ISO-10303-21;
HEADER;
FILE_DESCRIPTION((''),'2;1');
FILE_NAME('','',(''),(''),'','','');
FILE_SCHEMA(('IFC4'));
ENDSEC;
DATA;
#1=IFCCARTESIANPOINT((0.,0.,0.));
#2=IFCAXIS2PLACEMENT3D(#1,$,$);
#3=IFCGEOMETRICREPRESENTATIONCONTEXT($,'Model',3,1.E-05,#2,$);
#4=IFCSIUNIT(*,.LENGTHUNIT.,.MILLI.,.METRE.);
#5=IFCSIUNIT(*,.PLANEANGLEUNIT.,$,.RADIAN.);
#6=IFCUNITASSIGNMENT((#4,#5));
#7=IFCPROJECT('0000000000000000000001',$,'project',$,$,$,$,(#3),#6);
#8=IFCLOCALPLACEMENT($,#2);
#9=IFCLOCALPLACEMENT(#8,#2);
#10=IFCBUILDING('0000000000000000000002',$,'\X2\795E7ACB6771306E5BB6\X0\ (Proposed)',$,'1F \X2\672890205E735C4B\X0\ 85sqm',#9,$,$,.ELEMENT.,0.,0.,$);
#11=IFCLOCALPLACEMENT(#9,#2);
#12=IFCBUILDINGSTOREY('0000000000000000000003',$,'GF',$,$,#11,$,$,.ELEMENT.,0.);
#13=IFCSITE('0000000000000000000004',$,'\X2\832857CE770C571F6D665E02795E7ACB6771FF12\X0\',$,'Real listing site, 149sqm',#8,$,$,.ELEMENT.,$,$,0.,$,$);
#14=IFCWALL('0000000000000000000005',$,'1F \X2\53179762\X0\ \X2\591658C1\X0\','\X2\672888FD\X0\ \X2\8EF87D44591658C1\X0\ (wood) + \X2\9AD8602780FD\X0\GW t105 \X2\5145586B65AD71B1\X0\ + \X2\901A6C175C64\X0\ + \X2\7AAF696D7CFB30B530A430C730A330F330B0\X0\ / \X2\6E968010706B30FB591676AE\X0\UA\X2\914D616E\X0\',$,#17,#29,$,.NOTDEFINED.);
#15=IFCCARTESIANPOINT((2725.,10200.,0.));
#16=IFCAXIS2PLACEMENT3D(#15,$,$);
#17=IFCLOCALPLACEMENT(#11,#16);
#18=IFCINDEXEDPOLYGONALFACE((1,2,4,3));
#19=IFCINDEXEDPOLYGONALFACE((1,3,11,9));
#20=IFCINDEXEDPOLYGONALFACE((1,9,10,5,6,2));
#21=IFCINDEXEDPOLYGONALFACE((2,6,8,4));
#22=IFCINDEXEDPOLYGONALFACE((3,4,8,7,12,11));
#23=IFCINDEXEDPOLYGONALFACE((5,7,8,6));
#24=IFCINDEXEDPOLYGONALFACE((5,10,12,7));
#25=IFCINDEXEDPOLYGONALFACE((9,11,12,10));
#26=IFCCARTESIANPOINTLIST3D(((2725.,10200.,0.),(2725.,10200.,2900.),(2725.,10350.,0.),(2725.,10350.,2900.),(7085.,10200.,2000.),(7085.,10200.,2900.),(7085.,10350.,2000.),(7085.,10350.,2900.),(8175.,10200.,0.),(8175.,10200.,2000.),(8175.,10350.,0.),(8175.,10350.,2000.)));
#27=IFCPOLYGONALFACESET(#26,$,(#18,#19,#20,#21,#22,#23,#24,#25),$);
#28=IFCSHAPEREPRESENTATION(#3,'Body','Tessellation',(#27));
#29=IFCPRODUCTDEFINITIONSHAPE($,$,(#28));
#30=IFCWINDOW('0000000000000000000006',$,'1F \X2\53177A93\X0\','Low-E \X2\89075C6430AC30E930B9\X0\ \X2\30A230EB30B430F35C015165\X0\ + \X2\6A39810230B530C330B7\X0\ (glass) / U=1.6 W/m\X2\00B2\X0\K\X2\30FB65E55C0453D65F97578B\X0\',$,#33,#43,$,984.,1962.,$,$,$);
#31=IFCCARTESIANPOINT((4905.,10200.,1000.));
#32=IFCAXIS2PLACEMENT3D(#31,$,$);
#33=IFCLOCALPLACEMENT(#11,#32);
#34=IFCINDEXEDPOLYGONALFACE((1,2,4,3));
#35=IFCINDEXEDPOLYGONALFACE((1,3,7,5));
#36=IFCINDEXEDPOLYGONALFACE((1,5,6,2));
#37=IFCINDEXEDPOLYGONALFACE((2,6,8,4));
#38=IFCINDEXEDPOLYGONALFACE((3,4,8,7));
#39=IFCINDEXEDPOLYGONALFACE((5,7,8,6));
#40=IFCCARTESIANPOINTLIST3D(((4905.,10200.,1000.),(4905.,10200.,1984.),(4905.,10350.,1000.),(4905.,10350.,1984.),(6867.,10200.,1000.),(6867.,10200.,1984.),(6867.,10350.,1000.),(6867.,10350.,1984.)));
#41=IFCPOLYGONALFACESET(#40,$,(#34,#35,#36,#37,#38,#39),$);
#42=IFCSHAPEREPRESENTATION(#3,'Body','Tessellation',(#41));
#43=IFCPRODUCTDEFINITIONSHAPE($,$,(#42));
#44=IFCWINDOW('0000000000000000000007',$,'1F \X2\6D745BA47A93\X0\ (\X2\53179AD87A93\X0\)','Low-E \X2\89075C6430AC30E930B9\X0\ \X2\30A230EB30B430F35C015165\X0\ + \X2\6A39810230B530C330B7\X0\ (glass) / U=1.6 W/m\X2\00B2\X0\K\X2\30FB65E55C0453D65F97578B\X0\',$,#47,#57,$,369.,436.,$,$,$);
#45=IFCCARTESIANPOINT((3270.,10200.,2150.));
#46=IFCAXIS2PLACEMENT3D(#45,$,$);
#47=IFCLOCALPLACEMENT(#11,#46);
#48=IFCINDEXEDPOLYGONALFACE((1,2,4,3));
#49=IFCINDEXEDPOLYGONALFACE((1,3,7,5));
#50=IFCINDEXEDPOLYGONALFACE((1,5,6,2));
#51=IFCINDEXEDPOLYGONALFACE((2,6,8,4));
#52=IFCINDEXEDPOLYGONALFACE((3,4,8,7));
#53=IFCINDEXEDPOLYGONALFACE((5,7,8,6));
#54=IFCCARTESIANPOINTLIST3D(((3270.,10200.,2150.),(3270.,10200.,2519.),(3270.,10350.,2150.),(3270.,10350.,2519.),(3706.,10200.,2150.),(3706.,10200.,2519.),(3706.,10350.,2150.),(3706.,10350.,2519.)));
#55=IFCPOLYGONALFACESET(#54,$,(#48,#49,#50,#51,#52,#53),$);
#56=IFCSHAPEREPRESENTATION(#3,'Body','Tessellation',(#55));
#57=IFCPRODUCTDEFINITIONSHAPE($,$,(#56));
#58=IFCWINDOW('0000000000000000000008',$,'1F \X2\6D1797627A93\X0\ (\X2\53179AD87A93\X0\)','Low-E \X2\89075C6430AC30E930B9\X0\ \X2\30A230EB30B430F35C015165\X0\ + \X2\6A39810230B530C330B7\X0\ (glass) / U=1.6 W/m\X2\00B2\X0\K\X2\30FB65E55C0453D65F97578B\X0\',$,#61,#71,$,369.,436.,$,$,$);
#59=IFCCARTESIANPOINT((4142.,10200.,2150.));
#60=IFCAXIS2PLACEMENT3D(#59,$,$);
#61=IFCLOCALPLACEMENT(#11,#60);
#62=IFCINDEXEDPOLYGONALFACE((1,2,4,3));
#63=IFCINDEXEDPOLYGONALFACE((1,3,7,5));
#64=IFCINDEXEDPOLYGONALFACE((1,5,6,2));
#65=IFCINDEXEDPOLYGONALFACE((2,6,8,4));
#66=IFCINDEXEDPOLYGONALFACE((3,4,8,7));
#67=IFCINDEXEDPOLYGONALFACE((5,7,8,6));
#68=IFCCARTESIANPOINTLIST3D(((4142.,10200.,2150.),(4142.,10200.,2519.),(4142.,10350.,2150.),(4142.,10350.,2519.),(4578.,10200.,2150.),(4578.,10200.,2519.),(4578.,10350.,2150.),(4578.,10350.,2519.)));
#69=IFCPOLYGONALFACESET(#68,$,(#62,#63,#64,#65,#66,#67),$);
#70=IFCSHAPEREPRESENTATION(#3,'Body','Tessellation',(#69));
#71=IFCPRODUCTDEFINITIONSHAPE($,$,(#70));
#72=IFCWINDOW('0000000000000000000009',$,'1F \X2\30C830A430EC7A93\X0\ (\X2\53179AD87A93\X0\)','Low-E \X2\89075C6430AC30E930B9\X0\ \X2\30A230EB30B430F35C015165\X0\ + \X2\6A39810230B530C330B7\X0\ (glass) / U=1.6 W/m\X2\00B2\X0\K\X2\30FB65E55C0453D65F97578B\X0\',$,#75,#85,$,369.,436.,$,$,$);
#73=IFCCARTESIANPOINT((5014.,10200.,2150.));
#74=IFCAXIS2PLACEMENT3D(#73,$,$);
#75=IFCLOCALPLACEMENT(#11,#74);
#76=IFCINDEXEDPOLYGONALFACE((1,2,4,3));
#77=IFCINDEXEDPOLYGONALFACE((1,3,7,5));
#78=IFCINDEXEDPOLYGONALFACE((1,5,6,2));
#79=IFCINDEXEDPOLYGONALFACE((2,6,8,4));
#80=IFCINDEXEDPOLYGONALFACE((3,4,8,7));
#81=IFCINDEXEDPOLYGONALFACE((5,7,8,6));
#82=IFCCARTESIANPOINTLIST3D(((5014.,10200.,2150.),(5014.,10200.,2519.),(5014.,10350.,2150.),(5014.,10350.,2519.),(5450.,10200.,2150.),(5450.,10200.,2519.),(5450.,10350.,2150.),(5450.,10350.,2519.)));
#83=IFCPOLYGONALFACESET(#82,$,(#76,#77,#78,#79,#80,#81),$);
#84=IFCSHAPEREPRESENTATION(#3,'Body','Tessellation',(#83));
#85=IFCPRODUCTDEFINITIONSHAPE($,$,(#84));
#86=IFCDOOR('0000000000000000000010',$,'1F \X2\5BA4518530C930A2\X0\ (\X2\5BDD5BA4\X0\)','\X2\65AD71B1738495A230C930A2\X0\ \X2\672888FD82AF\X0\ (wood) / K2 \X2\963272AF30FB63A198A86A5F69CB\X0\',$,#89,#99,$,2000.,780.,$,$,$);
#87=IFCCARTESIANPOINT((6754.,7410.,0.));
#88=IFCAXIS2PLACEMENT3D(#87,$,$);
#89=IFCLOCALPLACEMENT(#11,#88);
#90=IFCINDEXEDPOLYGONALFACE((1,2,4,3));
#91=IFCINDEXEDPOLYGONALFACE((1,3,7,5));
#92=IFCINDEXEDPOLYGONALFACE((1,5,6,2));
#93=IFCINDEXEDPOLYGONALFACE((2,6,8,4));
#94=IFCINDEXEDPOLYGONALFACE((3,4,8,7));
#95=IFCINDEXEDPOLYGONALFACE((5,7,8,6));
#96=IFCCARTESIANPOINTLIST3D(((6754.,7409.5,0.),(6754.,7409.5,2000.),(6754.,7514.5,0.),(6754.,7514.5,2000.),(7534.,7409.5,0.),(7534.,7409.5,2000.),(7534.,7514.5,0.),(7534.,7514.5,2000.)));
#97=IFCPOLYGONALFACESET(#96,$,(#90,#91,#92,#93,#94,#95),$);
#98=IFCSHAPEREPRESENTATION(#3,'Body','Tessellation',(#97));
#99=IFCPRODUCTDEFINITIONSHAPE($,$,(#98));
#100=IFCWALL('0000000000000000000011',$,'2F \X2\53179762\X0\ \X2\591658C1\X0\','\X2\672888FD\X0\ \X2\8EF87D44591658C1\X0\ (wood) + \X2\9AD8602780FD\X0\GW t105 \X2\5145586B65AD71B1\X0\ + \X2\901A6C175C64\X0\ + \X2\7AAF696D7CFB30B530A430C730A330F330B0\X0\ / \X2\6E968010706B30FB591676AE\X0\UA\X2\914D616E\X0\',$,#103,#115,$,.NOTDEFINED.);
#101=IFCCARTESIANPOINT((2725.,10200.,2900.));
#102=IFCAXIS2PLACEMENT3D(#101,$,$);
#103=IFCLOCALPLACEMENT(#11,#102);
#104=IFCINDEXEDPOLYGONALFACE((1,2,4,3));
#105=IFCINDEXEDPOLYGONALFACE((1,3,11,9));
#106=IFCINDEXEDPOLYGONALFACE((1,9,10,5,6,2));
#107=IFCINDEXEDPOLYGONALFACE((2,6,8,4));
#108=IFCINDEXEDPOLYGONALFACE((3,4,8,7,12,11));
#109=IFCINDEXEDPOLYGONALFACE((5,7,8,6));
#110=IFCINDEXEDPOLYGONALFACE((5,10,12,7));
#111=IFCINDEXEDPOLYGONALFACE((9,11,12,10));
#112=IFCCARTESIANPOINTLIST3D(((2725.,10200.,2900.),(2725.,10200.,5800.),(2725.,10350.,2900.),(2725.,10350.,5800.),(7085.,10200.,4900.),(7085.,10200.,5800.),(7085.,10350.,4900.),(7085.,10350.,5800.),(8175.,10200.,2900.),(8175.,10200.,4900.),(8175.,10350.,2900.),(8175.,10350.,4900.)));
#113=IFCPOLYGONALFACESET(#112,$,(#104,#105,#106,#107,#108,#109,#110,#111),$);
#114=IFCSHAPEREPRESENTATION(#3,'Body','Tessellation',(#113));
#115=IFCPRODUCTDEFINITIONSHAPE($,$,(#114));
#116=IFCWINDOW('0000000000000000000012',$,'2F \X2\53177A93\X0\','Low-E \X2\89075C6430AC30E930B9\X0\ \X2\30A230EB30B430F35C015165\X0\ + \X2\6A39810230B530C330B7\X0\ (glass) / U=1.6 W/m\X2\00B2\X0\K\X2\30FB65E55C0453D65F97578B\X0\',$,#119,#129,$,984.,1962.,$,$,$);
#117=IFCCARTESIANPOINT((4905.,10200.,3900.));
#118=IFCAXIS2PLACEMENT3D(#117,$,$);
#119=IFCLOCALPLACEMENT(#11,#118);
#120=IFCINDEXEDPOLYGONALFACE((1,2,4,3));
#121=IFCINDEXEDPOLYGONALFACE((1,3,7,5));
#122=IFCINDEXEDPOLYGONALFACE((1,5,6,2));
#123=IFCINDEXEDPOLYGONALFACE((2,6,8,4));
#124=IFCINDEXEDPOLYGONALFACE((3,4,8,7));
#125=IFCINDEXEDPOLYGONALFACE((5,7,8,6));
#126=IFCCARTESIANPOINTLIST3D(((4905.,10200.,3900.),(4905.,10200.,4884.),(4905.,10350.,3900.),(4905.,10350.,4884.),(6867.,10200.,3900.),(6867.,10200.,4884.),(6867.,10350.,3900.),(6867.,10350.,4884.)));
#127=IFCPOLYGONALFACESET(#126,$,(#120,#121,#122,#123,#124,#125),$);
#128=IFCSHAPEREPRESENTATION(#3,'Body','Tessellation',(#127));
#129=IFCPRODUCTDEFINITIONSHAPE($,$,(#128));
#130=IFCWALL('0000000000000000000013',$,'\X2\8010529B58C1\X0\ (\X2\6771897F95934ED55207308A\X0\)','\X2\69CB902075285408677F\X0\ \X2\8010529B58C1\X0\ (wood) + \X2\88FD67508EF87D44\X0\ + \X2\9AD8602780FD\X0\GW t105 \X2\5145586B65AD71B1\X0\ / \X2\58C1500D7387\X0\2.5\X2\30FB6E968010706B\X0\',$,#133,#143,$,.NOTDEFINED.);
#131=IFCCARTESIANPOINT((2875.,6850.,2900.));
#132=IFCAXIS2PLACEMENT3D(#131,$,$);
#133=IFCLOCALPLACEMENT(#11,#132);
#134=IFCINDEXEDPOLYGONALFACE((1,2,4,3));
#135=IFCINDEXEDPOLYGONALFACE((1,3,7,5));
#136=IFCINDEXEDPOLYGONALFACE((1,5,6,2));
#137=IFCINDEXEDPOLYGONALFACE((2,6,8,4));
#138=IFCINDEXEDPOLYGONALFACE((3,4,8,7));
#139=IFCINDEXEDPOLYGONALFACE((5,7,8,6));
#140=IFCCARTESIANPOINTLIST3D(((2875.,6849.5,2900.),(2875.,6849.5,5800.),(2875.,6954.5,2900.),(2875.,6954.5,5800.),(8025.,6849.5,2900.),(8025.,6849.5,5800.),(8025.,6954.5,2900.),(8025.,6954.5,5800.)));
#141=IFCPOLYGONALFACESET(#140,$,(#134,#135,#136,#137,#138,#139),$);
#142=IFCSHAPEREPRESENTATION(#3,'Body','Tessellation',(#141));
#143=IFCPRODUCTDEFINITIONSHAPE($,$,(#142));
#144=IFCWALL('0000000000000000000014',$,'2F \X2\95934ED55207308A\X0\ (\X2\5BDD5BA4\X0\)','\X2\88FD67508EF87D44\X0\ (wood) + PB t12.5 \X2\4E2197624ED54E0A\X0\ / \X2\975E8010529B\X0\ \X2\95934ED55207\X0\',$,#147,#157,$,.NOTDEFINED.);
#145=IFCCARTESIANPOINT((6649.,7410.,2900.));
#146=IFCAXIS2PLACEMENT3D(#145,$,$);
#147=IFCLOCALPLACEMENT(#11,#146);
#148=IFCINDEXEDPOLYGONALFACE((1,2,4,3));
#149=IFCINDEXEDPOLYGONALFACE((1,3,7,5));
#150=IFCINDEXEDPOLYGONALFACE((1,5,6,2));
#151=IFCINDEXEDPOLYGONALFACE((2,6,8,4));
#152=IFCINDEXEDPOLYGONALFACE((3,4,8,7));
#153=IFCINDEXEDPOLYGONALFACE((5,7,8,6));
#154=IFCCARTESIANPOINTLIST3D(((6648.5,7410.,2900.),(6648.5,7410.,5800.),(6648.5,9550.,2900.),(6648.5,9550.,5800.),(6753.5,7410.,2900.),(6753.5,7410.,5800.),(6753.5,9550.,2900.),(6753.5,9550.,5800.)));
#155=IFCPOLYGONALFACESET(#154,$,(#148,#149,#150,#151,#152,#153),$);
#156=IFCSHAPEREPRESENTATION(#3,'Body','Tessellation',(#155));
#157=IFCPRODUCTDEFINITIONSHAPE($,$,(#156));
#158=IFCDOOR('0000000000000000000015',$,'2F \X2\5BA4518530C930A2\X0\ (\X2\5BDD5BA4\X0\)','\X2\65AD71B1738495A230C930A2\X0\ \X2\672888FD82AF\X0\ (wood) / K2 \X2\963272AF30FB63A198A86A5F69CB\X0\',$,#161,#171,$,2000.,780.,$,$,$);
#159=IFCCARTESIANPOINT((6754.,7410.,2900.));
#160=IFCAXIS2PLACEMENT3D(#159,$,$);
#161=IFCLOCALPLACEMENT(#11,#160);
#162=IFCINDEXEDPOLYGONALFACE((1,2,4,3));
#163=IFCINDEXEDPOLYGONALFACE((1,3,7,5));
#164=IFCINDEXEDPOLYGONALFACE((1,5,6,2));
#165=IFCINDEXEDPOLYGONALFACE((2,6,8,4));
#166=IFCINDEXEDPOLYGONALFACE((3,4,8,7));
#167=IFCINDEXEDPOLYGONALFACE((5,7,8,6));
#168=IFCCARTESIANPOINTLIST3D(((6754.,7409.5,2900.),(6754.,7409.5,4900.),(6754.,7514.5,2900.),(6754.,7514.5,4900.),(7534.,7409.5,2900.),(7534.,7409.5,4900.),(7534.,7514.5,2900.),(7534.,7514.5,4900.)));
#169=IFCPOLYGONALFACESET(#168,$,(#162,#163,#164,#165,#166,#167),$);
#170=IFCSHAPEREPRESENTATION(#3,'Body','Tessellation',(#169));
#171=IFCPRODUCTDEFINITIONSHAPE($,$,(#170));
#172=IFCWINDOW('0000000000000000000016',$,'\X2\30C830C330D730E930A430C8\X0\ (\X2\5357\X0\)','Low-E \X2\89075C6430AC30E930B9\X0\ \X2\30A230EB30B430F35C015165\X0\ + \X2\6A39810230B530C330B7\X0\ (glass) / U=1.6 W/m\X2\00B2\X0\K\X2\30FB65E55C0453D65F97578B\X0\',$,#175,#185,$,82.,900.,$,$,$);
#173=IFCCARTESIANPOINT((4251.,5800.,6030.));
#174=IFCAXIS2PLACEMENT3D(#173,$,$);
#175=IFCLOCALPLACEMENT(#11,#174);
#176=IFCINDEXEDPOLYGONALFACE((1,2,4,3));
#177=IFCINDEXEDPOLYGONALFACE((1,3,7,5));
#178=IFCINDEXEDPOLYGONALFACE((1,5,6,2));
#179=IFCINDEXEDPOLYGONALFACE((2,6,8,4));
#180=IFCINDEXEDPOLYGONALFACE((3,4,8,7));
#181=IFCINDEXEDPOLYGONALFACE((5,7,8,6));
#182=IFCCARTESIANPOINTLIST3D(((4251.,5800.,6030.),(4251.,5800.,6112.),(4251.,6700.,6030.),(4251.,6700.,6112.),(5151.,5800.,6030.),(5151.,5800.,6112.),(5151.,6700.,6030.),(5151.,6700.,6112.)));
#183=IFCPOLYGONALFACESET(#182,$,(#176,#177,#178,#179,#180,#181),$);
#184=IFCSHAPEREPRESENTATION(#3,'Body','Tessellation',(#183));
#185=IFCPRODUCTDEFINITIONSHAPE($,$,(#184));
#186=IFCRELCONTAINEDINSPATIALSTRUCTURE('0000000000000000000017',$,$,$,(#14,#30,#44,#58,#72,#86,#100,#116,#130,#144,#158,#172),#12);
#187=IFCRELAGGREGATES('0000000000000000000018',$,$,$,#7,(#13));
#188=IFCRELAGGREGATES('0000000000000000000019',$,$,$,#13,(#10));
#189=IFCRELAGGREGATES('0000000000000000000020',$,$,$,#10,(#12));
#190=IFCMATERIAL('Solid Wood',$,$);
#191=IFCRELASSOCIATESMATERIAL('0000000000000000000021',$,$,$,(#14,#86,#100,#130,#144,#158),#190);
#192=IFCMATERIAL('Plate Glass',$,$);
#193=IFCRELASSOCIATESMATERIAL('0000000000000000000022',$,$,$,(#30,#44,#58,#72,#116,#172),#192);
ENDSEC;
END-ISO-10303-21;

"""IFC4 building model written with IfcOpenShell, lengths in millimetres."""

from ifc_helpers import new_model, si_unit, frame, frame_2d, origin, place, context, project, spatial, rectangle, extrude, material, element, fill, save


model = new_model("IFC4")

# Units and contexts
model_context = context("Model", 3, precision=1e-05, world=origin())
ifc_project = project(units=[si_unit("LENGTHUNIT", "METRE", prefix="MILLI"), si_unit("PLANEANGLEUNIT", "RADIAN")], contexts=[model_context])

# Site, building, storey
site_placement = place(None, origin())
site = spatial("IfcSite", under=ifc_project, at=site_placement, Name="茨城県土浦市神立東２", ObjectType="Real listing site, 149sqm", CompositionType="ELEMENT", RefElevation=0.0)
building_placement = place(site_placement, origin())
building = spatial("IfcBuilding", under=site, at=building_placement, Name="神立東の家 (Proposed)", ObjectType="1F 木造平屋 85sqm", CompositionType="ELEMENT", ElevationOfRefHeight=0.0, ElevationOfTerrain=0.0)
storey_placement = place(building_placement, origin())
storey = spatial("IfcBuildingStorey", under=building, at=storey_placement, Name="GF", CompositionType="ELEMENT", Elevation=0.0)

# Wall, openings, windows
ifc_material_1 = material(Name="Solid Wood")
wall_1_placement = place(storey_placement, frame((2725.0, 10200.0, 0.0)))
wall_1 = element("IfcWall", 1, at=wall_1_placement, inside=storey, material=ifc_material_1, Name="1F 北面 外壁", Description="木製 軸組外壁 (wood) + 高性能GW t105 充填断熱 + 通気層 + 窯業系サイディング / 準耐火・外皮UA配慮", PredefinedType="NOTDEFINED", context=model_context, shape_type="SweptSolid", body=[
    extrude(rectangle(XDim=5450.0, YDim=150.0, at=frame_2d((2725.0, 75.0))), frame((2725.0, 10200.0, 0.0)), (0.0, 0.0, 1.0), 2900.0),
])
opening_1_placement = place(storey_placement, frame((4905.0, 10200.0, 1000.0)))
opening_1 = element("IfcOpeningElement", 2, at=opening_1_placement, cuts=wall_1, PredefinedType="NOTDEFINED", context=model_context, shape_type="SweptSolid", body=[
    extrude(rectangle(XDim=1962.0, YDim=150.0, at=frame_2d((981.0, 75.0))), frame((4905.0, 10200.0, 1000.0)), (0.0, 0.0, 1.0), 984.0),
])
opening_2_placement = place(storey_placement, frame((3270.0, 10200.0, 2150.0)))
opening_2 = element("IfcOpeningElement", 3, at=opening_2_placement, cuts=wall_1, PredefinedType="NOTDEFINED", context=model_context, shape_type="SweptSolid", body=[
    extrude(rectangle(XDim=436.0, YDim=150.0, at=frame_2d((218.0, 75.0))), frame((3270.0, 10200.0, 2150.0)), (0.0, 0.0, 1.0), 369.0),
])
opening_3_placement = place(storey_placement, frame((4142.0, 10200.0, 2150.0)))
opening_3 = element("IfcOpeningElement", 4, at=opening_3_placement, cuts=wall_1, PredefinedType="NOTDEFINED", context=model_context, shape_type="SweptSolid", body=[
    extrude(rectangle(XDim=436.0, YDim=150.0, at=frame_2d((218.0, 75.0))), frame((4142.0, 10200.0, 2150.0)), (0.0, 0.0, 1.0), 369.0),
])
opening_4_placement = place(storey_placement, frame((5014.0, 10200.0, 2150.0)))
opening_4 = element("IfcOpeningElement", 5, at=opening_4_placement, cuts=wall_1, PredefinedType="NOTDEFINED", context=model_context, shape_type="SweptSolid", body=[
    extrude(rectangle(XDim=436.0, YDim=150.0, at=frame_2d((218.0, 75.0))), frame((5014.0, 10200.0, 2150.0)), (0.0, 0.0, 1.0), 369.0),
])
ifc_material_2 = material(Name="Plate Glass")
window_1_placement = place(storey_placement, frame((4905.0, 10200.0, 1000.0)))
window_1 = element("IfcWindow", 6, at=window_1_placement, inside=storey, material=ifc_material_2, Name="1F 北窓", Description="Low-E 複層ガラス アルゴン封入 + 樹脂サッシ (glass) / U=1.6 W/m²K・日射取得型", OverallHeight=984.0, OverallWidth=1962.0, context=model_context, shape_type="SweptSolid", body=[
    extrude(rectangle(XDim=1962.0, YDim=150.0, at=frame_2d((981.0, 75.0))), frame((4905.0, 10200.0, 1000.0)), (0.0, 0.0, 1.0), 984.0),
])
fill(opening_1, window_1)
window_2_placement = place(storey_placement, frame((3270.0, 10200.0, 2150.0)))
window_2 = element("IfcWindow", 7, at=window_2_placement, inside=storey, material=ifc_material_2, Name="1F 浴室窓 (北高窓)", Description="Low-E 複層ガラス アルゴン封入 + 樹脂サッシ (glass) / U=1.6 W/m²K・日射取得型", OverallHeight=369.0, OverallWidth=436.0, context=model_context, shape_type="SweptSolid", body=[
    extrude(rectangle(XDim=436.0, YDim=150.0, at=frame_2d((218.0, 75.0))), frame((3270.0, 10200.0, 2150.0)), (0.0, 0.0, 1.0), 369.0),
])
fill(opening_2, window_2)
window_3_placement = place(storey_placement, frame((4142.0, 10200.0, 2150.0)))
window_3 = element("IfcWindow", 8, at=window_3_placement, inside=storey, material=ifc_material_2, Name="1F 洗面窓 (北高窓)", Description="Low-E 複層ガラス アルゴン封入 + 樹脂サッシ (glass) / U=1.6 W/m²K・日射取得型", OverallHeight=369.0, OverallWidth=436.0, context=model_context, shape_type="SweptSolid", body=[
    extrude(rectangle(XDim=436.0, YDim=150.0, at=frame_2d((218.0, 75.0))), frame((4142.0, 10200.0, 2150.0)), (0.0, 0.0, 1.0), 369.0),
])
fill(opening_3, window_3)
window_4_placement = place(storey_placement, frame((5014.0, 10200.0, 2150.0)))
window_4 = element("IfcWindow", 9, at=window_4_placement, inside=storey, material=ifc_material_2, Name="1F トイレ窓 (北高窓)", Description="Low-E 複層ガラス アルゴン封入 + 樹脂サッシ (glass) / U=1.6 W/m²K・日射取得型", OverallHeight=369.0, OverallWidth=436.0, context=model_context, shape_type="SweptSolid", body=[
    extrude(rectangle(XDim=436.0, YDim=150.0, at=frame_2d((218.0, 75.0))), frame((5014.0, 10200.0, 2150.0)), (0.0, 0.0, 1.0), 369.0),
])
fill(opening_4, window_4)

# Door
door_1_placement = place(storey_placement, frame((6754.0, 7410.0, 0.0)))
element("IfcDoor", 10, at=door_1_placement, inside=storey, material=ifc_material_1, Name="1F 室内ドア (寝室)", Description="断熱玄関ドア 木製芯 (wood) / K2 防犯・採風機構", OverallHeight=2000.0, OverallWidth=780.0, context=model_context, shape_type="SweptSolid", body=[
    extrude(rectangle(XDim=780.0, YDim=105.0, at=frame_2d((390.0, 52.0))), frame((6754.0, 7410.0, 0.0)), (0.0, 0.0, 1.0), 2000.0),
])

# Wall, opening, window
wall_2_placement = place(storey_placement, frame((2725.0, 10200.0, 2900.0)))
wall_2 = element("IfcWall", 11, at=wall_2_placement, inside=storey, material=ifc_material_1, Name="2F 北面 外壁", Description="木製 軸組外壁 (wood) + 高性能GW t105 充填断熱 + 通気層 + 窯業系サイディング / 準耐火・外皮UA配慮", PredefinedType="NOTDEFINED", context=model_context, shape_type="SweptSolid", body=[
    extrude(rectangle(XDim=5450.0, YDim=150.0, at=frame_2d((2725.0, 75.0))), frame((2725.0, 10200.0, 2900.0)), (0.0, 0.0, 1.0), 2900.0),
])
opening_5_placement = place(storey_placement, frame((4905.0, 10200.0, 3900.0)))
opening_5 = element("IfcOpeningElement", 12, at=opening_5_placement, cuts=wall_2, PredefinedType="NOTDEFINED", context=model_context, shape_type="SweptSolid", body=[
    extrude(rectangle(XDim=1962.0, YDim=150.0, at=frame_2d((981.0, 75.0))), frame((4905.0, 10200.0, 3900.0)), (0.0, 0.0, 1.0), 984.0),
])
window_5_placement = place(storey_placement, frame((4905.0, 10200.0, 3900.0)))
window_5 = element("IfcWindow", 13, at=window_5_placement, inside=storey, material=ifc_material_2, Name="2F 北窓", Description="Low-E 複層ガラス アルゴン封入 + 樹脂サッシ (glass) / U=1.6 W/m²K・日射取得型", OverallHeight=984.0, OverallWidth=1962.0, context=model_context, shape_type="SweptSolid", body=[
    extrude(rectangle(XDim=1962.0, YDim=150.0, at=frame_2d((981.0, 75.0))), frame((4905.0, 10200.0, 3900.0)), (0.0, 0.0, 1.0), 984.0),
])
fill(opening_5, window_5)

# Walls
wall_3_placement = place(storey_placement, frame((2875.0, 6850.0, 2900.0)))
element("IfcWall", 14, at=wall_3_placement, inside=storey, material=ifc_material_1, Name="耐力壁 (東西間仕切り)", Description="構造用合板 耐力壁 (wood) + 製材軸組 + 高性能GW t105 充填断熱 / 壁倍率2.5・準耐火", PredefinedType="NOTDEFINED", context=model_context, shape_type="SweptSolid", body=[
    extrude(rectangle(XDim=5150.0, YDim=105.0, at=frame_2d((2575.0, 52.0))), frame((2875.0, 6850.0, 2900.0)), (0.0, 0.0, 1.0), 2900.0),
])
wall_4_placement = place(storey_placement, frame((6649.0, 7410.0, 2900.0)))
element("IfcWall", 15, at=wall_4_placement, inside=storey, material=ifc_material_1, Name="2F 間仕切り (寝室)", Description="製材軸組 (wood) + PB t12.5 両面仕上 / 非耐力 間仕切", PredefinedType="NOTDEFINED", context=model_context, shape_type="SweptSolid", body=[
    extrude(rectangle(XDim=105.0, YDim=2140.0, at=frame_2d((52.0, 1070.0))), frame((6649.0, 7410.0, 2900.0)), (0.0, 0.0, 1.0), 2900.0),
])

# Door
door_2_placement = place(storey_placement, frame((6754.0, 7410.0, 2900.0)))
element("IfcDoor", 16, at=door_2_placement, inside=storey, material=ifc_material_1, Name="2F 室内ドア (寝室)", Description="断熱玄関ドア 木製芯 (wood) / K2 防犯・採風機構", OverallHeight=2000.0, OverallWidth=780.0, context=model_context, shape_type="SweptSolid", body=[
    extrude(rectangle(XDim=780.0, YDim=105.0, at=frame_2d((390.0, 52.0))), frame((6754.0, 7410.0, 2900.0)), (0.0, 0.0, 1.0), 2000.0),
])

# Window
window_6_placement = place(storey_placement, frame((4251.0, 5800.0, 6030.0)))
element("IfcWindow", 17, at=window_6_placement, inside=storey, material=ifc_material_2, Name="トップライト (南)", Description="Low-E 複層ガラス アルゴン封入 + 樹脂サッシ (glass) / U=1.6 W/m²K・日射取得型", OverallHeight=82.0, OverallWidth=900.0, context=model_context, shape_type="SweptSolid", body=[
    extrude(rectangle(XDim=900.0, YDim=900.0, at=frame_2d((450.0, 450.0))), frame((4251.0, 5800.0, 6030.0)), (0.0, 0.0, 1.0), 82.0),
])

save(model, "model.ifc")
